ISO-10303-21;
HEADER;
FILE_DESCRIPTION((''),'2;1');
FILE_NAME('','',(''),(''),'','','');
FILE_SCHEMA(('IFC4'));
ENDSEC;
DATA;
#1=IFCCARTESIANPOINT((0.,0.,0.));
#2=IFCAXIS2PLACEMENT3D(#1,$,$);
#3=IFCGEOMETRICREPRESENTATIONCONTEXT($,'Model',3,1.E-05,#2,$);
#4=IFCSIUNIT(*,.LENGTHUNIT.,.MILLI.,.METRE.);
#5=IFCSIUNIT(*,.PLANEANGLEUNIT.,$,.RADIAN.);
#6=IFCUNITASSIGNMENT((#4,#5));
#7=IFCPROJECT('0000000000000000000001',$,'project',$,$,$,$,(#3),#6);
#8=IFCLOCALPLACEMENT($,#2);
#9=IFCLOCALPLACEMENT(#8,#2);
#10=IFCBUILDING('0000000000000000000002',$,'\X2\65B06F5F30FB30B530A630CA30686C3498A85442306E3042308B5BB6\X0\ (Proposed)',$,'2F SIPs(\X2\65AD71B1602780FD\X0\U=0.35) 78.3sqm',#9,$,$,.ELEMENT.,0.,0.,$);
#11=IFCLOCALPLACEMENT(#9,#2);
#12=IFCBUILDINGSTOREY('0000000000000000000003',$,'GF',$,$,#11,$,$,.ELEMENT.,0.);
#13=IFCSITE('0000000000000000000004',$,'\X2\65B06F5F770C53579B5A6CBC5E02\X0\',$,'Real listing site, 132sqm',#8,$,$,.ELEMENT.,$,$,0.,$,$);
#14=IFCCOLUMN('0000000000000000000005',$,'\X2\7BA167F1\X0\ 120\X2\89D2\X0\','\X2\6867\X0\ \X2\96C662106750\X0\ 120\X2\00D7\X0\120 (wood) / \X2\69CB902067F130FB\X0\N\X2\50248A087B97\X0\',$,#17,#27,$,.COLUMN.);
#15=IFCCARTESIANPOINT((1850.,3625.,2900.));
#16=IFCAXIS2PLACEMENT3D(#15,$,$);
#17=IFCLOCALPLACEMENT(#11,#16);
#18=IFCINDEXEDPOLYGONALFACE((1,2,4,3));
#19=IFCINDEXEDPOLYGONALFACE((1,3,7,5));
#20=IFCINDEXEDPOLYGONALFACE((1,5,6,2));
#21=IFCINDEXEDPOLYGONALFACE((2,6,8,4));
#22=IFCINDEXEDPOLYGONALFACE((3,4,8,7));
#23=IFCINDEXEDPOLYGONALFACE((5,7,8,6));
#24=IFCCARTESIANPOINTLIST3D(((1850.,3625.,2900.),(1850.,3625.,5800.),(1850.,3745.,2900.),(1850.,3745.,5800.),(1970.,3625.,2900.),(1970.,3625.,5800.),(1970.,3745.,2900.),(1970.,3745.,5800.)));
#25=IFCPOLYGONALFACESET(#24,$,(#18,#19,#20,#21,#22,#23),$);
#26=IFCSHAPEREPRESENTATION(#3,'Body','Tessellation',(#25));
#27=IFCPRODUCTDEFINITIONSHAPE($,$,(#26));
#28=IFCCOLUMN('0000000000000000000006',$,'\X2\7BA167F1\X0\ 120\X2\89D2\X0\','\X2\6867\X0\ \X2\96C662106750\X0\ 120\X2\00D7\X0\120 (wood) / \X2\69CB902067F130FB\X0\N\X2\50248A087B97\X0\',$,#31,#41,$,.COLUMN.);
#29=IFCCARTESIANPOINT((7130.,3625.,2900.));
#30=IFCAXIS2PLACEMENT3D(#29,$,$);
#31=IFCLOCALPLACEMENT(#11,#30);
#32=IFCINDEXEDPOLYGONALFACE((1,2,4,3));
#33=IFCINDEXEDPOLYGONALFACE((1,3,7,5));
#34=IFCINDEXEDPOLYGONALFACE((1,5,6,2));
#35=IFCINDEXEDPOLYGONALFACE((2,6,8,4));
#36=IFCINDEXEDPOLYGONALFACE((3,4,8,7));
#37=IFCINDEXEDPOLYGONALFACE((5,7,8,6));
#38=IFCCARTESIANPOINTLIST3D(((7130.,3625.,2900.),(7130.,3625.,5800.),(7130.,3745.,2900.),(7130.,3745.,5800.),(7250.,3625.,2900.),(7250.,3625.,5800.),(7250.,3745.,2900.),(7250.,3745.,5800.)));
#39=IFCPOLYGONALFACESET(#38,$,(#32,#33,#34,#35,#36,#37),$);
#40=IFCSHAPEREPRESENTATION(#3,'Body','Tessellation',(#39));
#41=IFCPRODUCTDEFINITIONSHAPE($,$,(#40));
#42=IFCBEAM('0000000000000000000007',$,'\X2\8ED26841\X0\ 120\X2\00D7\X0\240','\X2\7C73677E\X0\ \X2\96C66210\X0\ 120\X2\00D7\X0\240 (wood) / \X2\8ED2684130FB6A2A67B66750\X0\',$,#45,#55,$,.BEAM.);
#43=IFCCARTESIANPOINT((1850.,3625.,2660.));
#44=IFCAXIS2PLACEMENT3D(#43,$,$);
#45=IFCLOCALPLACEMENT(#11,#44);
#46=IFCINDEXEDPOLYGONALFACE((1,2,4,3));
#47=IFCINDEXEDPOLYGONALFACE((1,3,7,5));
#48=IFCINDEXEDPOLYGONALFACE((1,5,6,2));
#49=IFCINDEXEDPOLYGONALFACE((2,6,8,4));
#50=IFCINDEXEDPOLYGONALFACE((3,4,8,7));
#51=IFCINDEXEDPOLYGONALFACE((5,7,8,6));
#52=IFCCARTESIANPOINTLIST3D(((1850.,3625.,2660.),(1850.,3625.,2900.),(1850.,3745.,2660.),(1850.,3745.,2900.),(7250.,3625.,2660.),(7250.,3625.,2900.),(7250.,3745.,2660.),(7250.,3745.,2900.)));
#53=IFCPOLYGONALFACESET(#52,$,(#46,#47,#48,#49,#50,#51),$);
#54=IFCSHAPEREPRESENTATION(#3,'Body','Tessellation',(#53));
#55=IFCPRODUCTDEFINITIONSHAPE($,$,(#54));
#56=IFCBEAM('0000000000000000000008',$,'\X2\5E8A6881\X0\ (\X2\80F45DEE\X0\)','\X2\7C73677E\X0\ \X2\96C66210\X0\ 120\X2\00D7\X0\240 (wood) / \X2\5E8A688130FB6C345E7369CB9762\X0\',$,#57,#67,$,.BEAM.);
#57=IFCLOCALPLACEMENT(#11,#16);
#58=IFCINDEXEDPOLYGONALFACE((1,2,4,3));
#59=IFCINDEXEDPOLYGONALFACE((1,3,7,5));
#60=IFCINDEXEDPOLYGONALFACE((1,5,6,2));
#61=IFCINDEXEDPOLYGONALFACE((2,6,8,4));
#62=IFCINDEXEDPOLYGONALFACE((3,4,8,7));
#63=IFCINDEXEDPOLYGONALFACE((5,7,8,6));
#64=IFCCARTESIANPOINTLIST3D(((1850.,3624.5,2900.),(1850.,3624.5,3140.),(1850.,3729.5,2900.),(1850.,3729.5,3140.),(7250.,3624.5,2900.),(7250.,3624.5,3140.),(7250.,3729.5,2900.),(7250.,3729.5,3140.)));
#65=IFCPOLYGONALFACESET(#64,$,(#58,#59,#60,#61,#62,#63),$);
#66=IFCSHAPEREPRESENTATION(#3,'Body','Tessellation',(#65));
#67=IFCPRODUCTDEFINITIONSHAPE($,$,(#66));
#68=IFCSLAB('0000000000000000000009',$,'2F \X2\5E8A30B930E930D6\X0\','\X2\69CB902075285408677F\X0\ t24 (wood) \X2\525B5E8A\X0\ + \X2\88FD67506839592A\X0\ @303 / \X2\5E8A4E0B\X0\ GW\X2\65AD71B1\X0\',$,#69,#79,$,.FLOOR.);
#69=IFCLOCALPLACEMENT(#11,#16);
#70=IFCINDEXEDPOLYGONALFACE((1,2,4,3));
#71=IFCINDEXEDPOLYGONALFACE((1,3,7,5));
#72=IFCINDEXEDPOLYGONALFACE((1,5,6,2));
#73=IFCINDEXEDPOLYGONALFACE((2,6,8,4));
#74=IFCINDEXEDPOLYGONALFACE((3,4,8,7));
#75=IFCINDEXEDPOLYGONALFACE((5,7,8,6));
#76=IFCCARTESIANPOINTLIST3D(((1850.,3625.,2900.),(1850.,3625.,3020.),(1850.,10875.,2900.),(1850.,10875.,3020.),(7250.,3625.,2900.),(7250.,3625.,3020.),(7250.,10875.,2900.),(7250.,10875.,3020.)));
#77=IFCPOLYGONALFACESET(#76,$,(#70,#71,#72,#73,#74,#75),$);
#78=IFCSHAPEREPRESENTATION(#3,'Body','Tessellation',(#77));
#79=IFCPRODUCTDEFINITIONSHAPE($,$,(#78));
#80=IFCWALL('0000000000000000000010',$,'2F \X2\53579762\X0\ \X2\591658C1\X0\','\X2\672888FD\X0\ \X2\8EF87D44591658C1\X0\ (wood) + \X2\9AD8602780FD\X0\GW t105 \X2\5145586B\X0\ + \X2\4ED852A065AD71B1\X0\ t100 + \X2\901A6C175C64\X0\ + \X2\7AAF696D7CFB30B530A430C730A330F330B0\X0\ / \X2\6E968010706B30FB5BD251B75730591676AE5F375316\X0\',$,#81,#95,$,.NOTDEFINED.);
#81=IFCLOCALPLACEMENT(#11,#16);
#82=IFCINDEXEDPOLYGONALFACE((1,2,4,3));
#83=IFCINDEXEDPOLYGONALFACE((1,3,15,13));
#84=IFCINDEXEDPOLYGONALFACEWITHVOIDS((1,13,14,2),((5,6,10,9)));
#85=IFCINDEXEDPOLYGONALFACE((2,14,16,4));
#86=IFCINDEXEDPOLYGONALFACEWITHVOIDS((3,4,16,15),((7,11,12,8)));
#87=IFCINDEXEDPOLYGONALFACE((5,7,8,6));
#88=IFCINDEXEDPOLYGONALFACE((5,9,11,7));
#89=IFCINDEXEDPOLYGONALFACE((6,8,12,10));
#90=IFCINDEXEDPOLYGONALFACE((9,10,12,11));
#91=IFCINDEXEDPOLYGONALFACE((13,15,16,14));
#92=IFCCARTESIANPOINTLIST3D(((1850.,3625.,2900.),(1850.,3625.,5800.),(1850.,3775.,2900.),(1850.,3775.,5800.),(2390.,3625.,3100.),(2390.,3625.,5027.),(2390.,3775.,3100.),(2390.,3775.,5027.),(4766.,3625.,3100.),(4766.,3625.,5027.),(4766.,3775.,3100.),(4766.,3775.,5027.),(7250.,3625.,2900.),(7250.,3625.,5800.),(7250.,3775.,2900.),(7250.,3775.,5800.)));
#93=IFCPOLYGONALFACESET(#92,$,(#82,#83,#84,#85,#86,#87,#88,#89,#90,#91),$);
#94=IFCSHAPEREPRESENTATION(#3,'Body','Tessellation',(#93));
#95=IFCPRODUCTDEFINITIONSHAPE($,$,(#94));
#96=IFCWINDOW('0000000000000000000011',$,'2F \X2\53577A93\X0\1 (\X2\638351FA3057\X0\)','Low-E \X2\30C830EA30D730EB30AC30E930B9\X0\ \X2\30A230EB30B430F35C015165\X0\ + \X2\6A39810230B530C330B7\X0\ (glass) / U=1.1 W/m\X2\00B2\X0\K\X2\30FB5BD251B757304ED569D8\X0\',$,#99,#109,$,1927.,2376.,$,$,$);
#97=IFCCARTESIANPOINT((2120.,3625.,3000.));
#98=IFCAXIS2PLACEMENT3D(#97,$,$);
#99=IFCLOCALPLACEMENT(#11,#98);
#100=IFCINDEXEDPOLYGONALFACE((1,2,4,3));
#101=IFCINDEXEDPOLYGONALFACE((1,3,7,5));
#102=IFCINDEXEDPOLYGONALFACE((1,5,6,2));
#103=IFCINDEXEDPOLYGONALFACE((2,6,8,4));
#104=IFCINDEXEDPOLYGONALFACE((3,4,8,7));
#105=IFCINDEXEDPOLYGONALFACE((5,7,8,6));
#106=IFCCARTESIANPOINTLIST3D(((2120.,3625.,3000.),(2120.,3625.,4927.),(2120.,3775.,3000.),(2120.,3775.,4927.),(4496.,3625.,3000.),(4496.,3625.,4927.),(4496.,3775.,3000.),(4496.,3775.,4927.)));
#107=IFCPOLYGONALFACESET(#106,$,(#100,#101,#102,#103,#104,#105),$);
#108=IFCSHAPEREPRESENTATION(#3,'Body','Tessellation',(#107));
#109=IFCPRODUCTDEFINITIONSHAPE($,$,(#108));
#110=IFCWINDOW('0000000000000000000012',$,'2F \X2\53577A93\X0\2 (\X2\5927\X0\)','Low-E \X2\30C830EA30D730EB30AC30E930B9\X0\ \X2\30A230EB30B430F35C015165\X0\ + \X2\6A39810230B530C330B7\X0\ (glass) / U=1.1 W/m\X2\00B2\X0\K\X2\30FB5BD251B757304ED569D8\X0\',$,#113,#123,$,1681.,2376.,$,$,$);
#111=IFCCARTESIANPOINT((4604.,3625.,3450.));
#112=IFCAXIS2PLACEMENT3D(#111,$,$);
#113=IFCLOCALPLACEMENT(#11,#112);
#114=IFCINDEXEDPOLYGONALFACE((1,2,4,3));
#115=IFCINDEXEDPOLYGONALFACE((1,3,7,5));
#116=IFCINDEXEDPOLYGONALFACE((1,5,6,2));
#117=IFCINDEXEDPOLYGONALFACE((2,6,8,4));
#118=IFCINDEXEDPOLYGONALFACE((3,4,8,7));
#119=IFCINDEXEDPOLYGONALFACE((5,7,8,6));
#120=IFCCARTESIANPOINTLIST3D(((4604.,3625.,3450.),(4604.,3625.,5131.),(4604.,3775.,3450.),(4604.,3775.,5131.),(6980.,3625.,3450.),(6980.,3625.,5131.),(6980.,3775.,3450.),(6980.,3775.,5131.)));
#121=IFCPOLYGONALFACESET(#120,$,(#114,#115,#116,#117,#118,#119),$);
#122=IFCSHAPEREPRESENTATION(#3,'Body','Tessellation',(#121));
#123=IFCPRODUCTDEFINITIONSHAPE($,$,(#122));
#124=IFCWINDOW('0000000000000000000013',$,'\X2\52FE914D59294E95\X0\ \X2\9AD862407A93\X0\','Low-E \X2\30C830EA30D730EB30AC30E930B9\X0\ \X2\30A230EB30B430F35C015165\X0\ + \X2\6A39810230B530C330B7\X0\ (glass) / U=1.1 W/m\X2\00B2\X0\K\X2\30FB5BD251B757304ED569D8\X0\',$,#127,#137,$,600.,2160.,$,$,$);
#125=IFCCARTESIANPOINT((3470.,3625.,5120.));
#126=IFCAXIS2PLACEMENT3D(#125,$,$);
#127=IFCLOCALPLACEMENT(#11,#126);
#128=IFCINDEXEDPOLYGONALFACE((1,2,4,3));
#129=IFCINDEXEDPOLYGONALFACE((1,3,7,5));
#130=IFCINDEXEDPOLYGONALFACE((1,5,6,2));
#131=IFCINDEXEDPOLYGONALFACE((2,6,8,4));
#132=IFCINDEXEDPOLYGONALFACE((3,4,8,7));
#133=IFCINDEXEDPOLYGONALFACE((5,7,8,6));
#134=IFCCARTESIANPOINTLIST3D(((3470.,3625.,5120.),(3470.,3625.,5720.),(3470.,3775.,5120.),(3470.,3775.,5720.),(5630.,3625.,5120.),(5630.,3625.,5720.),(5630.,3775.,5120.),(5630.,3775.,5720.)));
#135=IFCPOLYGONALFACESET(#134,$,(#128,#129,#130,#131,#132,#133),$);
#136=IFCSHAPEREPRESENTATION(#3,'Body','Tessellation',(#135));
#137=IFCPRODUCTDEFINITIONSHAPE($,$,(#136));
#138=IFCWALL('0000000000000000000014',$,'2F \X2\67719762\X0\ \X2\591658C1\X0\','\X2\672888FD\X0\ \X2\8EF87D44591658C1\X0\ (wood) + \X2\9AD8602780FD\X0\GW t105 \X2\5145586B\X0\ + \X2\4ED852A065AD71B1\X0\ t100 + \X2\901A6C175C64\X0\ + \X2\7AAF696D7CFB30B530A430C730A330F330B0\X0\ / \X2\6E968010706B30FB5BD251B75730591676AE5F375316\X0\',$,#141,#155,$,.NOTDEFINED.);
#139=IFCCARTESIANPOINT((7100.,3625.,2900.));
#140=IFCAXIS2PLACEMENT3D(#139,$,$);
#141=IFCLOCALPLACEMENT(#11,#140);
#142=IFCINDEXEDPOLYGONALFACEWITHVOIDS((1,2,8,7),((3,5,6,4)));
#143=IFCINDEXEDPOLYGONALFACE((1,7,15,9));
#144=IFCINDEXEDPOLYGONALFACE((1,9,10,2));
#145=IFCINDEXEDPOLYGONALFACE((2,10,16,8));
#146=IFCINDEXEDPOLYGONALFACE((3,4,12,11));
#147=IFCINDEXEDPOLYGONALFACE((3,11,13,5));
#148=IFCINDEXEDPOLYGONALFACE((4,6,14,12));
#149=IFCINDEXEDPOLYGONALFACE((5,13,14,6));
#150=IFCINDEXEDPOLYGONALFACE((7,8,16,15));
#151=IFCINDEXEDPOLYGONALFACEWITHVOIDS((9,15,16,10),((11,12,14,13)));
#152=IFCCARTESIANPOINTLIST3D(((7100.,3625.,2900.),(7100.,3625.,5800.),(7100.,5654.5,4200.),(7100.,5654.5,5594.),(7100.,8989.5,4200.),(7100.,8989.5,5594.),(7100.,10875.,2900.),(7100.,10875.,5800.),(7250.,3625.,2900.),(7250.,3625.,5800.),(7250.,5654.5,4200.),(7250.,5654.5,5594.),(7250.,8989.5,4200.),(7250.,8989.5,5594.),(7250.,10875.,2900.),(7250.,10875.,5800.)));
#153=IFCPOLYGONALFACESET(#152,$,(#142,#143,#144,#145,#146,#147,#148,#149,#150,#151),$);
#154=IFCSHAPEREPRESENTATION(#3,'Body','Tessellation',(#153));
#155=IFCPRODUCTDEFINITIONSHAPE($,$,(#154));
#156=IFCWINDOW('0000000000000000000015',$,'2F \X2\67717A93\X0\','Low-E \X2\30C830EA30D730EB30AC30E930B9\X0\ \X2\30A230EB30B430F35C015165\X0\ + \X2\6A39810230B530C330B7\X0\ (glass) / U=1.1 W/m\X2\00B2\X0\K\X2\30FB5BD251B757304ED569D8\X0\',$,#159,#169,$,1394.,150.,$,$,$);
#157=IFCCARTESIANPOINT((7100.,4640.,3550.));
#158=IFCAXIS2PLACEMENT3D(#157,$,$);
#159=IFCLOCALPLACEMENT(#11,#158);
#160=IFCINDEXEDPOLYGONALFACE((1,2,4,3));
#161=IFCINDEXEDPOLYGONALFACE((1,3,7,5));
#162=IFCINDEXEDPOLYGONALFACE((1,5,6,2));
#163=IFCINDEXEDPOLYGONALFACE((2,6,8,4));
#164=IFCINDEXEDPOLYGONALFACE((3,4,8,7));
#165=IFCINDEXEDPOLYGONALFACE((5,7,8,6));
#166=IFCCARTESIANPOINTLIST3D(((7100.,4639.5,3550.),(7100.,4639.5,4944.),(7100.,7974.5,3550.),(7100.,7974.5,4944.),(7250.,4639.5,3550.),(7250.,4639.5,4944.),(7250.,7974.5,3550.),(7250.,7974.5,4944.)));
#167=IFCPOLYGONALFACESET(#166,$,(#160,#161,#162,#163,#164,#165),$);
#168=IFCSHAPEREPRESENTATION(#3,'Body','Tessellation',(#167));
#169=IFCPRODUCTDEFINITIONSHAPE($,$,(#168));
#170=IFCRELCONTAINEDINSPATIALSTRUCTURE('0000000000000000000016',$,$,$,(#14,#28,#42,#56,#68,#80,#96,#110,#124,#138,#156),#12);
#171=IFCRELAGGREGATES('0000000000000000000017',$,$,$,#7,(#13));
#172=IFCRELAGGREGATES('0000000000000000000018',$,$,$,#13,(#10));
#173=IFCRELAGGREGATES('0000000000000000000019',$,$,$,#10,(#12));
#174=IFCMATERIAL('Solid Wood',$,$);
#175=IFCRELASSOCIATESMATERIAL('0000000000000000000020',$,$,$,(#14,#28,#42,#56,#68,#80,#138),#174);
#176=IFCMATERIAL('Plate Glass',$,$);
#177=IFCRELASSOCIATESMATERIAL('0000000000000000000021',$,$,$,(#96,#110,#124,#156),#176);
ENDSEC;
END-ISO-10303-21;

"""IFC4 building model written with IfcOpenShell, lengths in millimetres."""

from ifc_helpers import new_model, si_unit, frame, frame_2d, origin, place, context, project, spatial, rectangle, extrude, material, element, fill, save


model = new_model("IFC4")

# Units and contexts
model_context = context("Model", 3, precision=1e-05, world=origin())
ifc_project = project(units=[si_unit("LENGTHUNIT", "METRE", prefix="MILLI"), si_unit("PLANEANGLEUNIT", "RADIAN")], contexts=[model_context])

# Site, building, storey
site_placement = place(None, origin())
site = spatial("IfcSite", under=ifc_project, at=site_placement, Name="新潟県南魚沼市", ObjectType="Real listing site, 132sqm", CompositionType="ELEMENT", RefElevation=0.0)
building_placement = place(site_placement, origin())
building = spatial("IfcBuilding", under=site, at=building_placement, Name="新潟・サウナと水風呂のある家 (Proposed)", ObjectType="2F SIPs(断熱性能U=0.35) 78.3sqm", CompositionType="ELEMENT", ElevationOfRefHeight=0.0, ElevationOfTerrain=0.0)
storey_placement = place(building_placement, origin())
storey = spatial("IfcBuildingStorey", under=building, at=storey_placement, Name="GF", CompositionType="ELEMENT", Elevation=0.0)

# Columns
ifc_material_1 = material(Name="Solid Wood")
column_1_placement = place(storey_placement, frame((1850.0, 3625.0, 2900.0)))
element("IfcColumn", 1, at=column_1_placement, inside=storey, material=ifc_material_1, Name="管柱 120角", Description="桧 集成材 120×120 (wood) / 構造柱・N値計算", PredefinedType="COLUMN", context=model_context, shape_type="SweptSolid", body=[
    extrude(rectangle(XDim=120.0, YDim=120.0, at=frame_2d((60.0, 60.0))), frame((1850.0, 3625.0, 2900.0)), (0.0, 0.0, 1.0), 2900.0),
])
column_2_placement = place(storey_placement, frame((7130.0, 3625.0, 2900.0)))
element("IfcColumn", 2, at=column_2_placement, inside=storey, material=ifc_material_1, Name="管柱 120角", Description="桧 集成材 120×120 (wood) / 構造柱・N値計算", PredefinedType="COLUMN", context=model_context, shape_type="SweptSolid", body=[
    extrude(rectangle(XDim=120.0, YDim=120.0, at=frame_2d((60.0, 60.0))), frame((7130.0, 3625.0, 2900.0)), (0.0, 0.0, 1.0), 2900.0),
])

# Beams
beam_1_placement = place(storey_placement, frame((1850.0, 3625.0, 2660.0)))
element("IfcBeam", 3, at=beam_1_placement, inside=storey, material=ifc_material_1, Name="軒桁 120×240", Description="米松 集成 120×240 (wood) / 軒桁・横架材", PredefinedType="BEAM", context=model_context, shape_type="SweptSolid", body=[
    extrude(rectangle(XDim=5400.0, YDim=120.0, at=frame_2d((2700.0, 60.0))), frame((1850.0, 3625.0, 2660.0)), (0.0, 0.0, 1.0), 240.0),
])
beam_2_placement = place(storey_placement, frame((1850.0, 3625.0, 2900.0)))
element("IfcBeam", 4, at=beam_2_placement, inside=storey, material=ifc_material_1, Name="床梁 (胴差)", Description="米松 集成 120×240 (wood) / 床梁・水平構面", PredefinedType="BEAM", context=model_context, shape_type="SweptSolid", body=[
    extrude(rectangle(XDim=5400.0, YDim=105.0, at=frame_2d((2700.0, 52.0))), frame((1850.0, 3625.0, 2900.0)), (0.0, 0.0, 1.0), 240.0),
])

# Slab
slab_placement = place(storey_placement, frame((1850.0, 3625.0, 2900.0)))
element("IfcSlab", 5, at=slab_placement, inside=storey, material=ifc_material_1, Name="2F 床スラブ", Description="構造用合板 t24 (wood) 剛床 + 製材根太 @303 / 床下 GW断熱", PredefinedType="FLOOR", context=model_context, shape_type="SweptSolid", body=[
    extrude(rectangle(XDim=5400.0, YDim=7250.0, at=frame_2d((2700.0, 3625.0))), frame((1850.0, 3625.0, 2900.0)), (0.0, 0.0, 1.0), 120.0),
])

# Wall, openings, windows
wall_1_placement = place(storey_placement, frame((1850.0, 3625.0, 2900.0)))
wall_1 = element("IfcWall", 6, at=wall_1_placement, inside=storey, material=ifc_material_1, Name="2F 南面 外壁", Description="木製 軸組外壁 (wood) + 高性能GW t105 充填 + 付加断熱 t100 + 通気層 + 窯業系サイディング / 準耐火・寒冷地外皮強化", PredefinedType="NOTDEFINED", context=model_context, shape_type="SweptSolid", body=[
    extrude(rectangle(XDim=5400.0, YDim=150.0, at=frame_2d((2700.0, 75.0))), frame((1850.0, 3625.0, 2900.0)), (0.0, 0.0, 1.0), 2900.0),
])
opening_1_placement = place(storey_placement, frame((2120.0, 3625.0, 3000.0)))
opening_1 = element("IfcOpeningElement", 7, at=opening_1_placement, cuts=wall_1, PredefinedType="NOTDEFINED", context=model_context, shape_type="SweptSolid", body=[
    extrude(rectangle(XDim=2376.0, YDim=150.0, at=frame_2d((1188.0, 75.0))), frame((2120.0, 3625.0, 3000.0)), (0.0, 0.0, 1.0), 1927.0),
])
opening_2_placement = place(storey_placement, frame((4604.0, 3625.0, 3450.0)))
opening_2 = element("IfcOpeningElement", 8, at=opening_2_placement, cuts=wall_1, PredefinedType="NOTDEFINED", context=model_context, shape_type="SweptSolid", body=[
    extrude(rectangle(XDim=2376.0, YDim=150.0, at=frame_2d((1188.0, 75.0))), frame((4604.0, 3625.0, 3450.0)), (0.0, 0.0, 1.0), 1681.0),
])
opening_3_placement = place(storey_placement, frame((3470.0, 3625.0, 5120.0)))
opening_3 = element("IfcOpeningElement", 9, at=opening_3_placement, cuts=wall_1, PredefinedType="NOTDEFINED", context=model_context, shape_type="SweptSolid", body=[
    extrude(rectangle(XDim=2160.0, YDim=150.0, at=frame_2d((1080.0, 75.0))), frame((3470.0, 3625.0, 5120.0)), (0.0, 0.0, 1.0), 600.0),
])
ifc_material_2 = material(Name="Plate Glass")
window_1_placement = place(storey_placement, frame((2120.0, 3625.0, 3000.0)))
window_1 = element("IfcWindow", 10, at=window_1_placement, inside=storey, material=ifc_material_2, Name="2F 南窓1 (掃出し)", Description="Low-E トリプルガラス アルゴン封入 + 樹脂サッシ (glass) / U=1.1 W/m²K・寒冷地仕様", OverallHeight=1927.0, OverallWidth=2376.0, context=model_context, shape_type="SweptSolid", body=[
    extrude(rectangle(XDim=2376.0, YDim=150.0, at=frame_2d((1188.0, 75.0))), frame((2120.0, 3625.0, 3000.0)), (0.0, 0.0, 1.0), 1927.0),
])
fill(opening_1, window_1)
window_2_placement = place(storey_placement, frame((4604.0, 3625.0, 3450.0)))
window_2 = element("IfcWindow", 11, at=window_2_placement, inside=storey, material=ifc_material_2, Name="2F 南窓2 (大)", Description="Low-E トリプルガラス アルゴン封入 + 樹脂サッシ (glass) / U=1.1 W/m²K・寒冷地仕様", OverallHeight=1681.0, OverallWidth=2376.0, context=model_context, shape_type="SweptSolid", body=[
    extrude(rectangle(XDim=2376.0, YDim=150.0, at=frame_2d((1188.0, 75.0))), frame((4604.0, 3625.0, 3450.0)), (0.0, 0.0, 1.0), 1681.0),
])
fill(opening_2, window_2)
window_3_placement = place(storey_placement, frame((3470.0, 3625.0, 5120.0)))
window_3 = element("IfcWindow", 12, at=window_3_placement, inside=storey, material=ifc_material_2, Name="勾配天井 高所窓", Description="Low-E トリプルガラス アルゴン封入 + 樹脂サッシ (glass) / U=1.1 W/m²K・寒冷地仕様", OverallHeight=600.0, OverallWidth=2160.0, context=model_context, shape_type="SweptSolid", body=[
    extrude(rectangle(XDim=2160.0, YDim=150.0, at=frame_2d((1080.0, 75.0))), frame((3470.0, 3625.0, 5120.0)), (0.0, 0.0, 1.0), 600.0),
])
fill(opening_3, window_3)

# Wall, opening, window
wall_2_placement = place(storey_placement, frame((7100.0, 3625.0, 2900.0)))
wall_2 = element("IfcWall", 13, at=wall_2_placement, inside=storey, material=ifc_material_1, Name="2F 東面 外壁", Description="木製 軸組外壁 (wood) + 高性能GW t105 充填 + 付加断熱 t100 + 通気層 + 窯業系サイディング / 準耐火・寒冷地外皮強化", PredefinedType="NOTDEFINED", context=model_context, shape_type="SweptSolid", body=[
    extrude(rectangle(XDim=150.0, YDim=7250.0, at=frame_2d((75.0, 3625.0))), frame((7100.0, 3625.0, 2900.0)), (0.0, 0.0, 1.0), 2900.0),
])
opening_4_placement = place(storey_placement, frame((7100.0, 4640.0, 3550.0)))
opening_4 = element("IfcOpeningElement", 14, at=opening_4_placement, cuts=wall_2, PredefinedType="NOTDEFINED", context=model_context, shape_type="SweptSolid", body=[
    extrude(rectangle(XDim=150.0, YDim=3335.0, at=frame_2d((75.0, 1667.0))), frame((7100.0, 4640.0, 3550.0)), (0.0, 0.0, 1.0), 1394.0),
])
window_4_placement = place(storey_placement, frame((7100.0, 4640.0, 3550.0)))
window_4 = element("IfcWindow", 15, at=window_4_placement, inside=storey, material=ifc_material_2, Name="2F 東窓", Description="Low-E トリプルガラス アルゴン封入 + 樹脂サッシ (glass) / U=1.1 W/m²K・寒冷地仕様", OverallHeight=1394.0, OverallWidth=150.0, context=model_context, shape_type="SweptSolid", body=[
    extrude(rectangle(XDim=150.0, YDim=3335.0, at=frame_2d((75.0, 1667.0))), frame((7100.0, 4640.0, 3550.0)), (0.0, 0.0, 1.0), 1394.0),
])
fill(opening_4, window_4)

save(model, "model.ifc")
